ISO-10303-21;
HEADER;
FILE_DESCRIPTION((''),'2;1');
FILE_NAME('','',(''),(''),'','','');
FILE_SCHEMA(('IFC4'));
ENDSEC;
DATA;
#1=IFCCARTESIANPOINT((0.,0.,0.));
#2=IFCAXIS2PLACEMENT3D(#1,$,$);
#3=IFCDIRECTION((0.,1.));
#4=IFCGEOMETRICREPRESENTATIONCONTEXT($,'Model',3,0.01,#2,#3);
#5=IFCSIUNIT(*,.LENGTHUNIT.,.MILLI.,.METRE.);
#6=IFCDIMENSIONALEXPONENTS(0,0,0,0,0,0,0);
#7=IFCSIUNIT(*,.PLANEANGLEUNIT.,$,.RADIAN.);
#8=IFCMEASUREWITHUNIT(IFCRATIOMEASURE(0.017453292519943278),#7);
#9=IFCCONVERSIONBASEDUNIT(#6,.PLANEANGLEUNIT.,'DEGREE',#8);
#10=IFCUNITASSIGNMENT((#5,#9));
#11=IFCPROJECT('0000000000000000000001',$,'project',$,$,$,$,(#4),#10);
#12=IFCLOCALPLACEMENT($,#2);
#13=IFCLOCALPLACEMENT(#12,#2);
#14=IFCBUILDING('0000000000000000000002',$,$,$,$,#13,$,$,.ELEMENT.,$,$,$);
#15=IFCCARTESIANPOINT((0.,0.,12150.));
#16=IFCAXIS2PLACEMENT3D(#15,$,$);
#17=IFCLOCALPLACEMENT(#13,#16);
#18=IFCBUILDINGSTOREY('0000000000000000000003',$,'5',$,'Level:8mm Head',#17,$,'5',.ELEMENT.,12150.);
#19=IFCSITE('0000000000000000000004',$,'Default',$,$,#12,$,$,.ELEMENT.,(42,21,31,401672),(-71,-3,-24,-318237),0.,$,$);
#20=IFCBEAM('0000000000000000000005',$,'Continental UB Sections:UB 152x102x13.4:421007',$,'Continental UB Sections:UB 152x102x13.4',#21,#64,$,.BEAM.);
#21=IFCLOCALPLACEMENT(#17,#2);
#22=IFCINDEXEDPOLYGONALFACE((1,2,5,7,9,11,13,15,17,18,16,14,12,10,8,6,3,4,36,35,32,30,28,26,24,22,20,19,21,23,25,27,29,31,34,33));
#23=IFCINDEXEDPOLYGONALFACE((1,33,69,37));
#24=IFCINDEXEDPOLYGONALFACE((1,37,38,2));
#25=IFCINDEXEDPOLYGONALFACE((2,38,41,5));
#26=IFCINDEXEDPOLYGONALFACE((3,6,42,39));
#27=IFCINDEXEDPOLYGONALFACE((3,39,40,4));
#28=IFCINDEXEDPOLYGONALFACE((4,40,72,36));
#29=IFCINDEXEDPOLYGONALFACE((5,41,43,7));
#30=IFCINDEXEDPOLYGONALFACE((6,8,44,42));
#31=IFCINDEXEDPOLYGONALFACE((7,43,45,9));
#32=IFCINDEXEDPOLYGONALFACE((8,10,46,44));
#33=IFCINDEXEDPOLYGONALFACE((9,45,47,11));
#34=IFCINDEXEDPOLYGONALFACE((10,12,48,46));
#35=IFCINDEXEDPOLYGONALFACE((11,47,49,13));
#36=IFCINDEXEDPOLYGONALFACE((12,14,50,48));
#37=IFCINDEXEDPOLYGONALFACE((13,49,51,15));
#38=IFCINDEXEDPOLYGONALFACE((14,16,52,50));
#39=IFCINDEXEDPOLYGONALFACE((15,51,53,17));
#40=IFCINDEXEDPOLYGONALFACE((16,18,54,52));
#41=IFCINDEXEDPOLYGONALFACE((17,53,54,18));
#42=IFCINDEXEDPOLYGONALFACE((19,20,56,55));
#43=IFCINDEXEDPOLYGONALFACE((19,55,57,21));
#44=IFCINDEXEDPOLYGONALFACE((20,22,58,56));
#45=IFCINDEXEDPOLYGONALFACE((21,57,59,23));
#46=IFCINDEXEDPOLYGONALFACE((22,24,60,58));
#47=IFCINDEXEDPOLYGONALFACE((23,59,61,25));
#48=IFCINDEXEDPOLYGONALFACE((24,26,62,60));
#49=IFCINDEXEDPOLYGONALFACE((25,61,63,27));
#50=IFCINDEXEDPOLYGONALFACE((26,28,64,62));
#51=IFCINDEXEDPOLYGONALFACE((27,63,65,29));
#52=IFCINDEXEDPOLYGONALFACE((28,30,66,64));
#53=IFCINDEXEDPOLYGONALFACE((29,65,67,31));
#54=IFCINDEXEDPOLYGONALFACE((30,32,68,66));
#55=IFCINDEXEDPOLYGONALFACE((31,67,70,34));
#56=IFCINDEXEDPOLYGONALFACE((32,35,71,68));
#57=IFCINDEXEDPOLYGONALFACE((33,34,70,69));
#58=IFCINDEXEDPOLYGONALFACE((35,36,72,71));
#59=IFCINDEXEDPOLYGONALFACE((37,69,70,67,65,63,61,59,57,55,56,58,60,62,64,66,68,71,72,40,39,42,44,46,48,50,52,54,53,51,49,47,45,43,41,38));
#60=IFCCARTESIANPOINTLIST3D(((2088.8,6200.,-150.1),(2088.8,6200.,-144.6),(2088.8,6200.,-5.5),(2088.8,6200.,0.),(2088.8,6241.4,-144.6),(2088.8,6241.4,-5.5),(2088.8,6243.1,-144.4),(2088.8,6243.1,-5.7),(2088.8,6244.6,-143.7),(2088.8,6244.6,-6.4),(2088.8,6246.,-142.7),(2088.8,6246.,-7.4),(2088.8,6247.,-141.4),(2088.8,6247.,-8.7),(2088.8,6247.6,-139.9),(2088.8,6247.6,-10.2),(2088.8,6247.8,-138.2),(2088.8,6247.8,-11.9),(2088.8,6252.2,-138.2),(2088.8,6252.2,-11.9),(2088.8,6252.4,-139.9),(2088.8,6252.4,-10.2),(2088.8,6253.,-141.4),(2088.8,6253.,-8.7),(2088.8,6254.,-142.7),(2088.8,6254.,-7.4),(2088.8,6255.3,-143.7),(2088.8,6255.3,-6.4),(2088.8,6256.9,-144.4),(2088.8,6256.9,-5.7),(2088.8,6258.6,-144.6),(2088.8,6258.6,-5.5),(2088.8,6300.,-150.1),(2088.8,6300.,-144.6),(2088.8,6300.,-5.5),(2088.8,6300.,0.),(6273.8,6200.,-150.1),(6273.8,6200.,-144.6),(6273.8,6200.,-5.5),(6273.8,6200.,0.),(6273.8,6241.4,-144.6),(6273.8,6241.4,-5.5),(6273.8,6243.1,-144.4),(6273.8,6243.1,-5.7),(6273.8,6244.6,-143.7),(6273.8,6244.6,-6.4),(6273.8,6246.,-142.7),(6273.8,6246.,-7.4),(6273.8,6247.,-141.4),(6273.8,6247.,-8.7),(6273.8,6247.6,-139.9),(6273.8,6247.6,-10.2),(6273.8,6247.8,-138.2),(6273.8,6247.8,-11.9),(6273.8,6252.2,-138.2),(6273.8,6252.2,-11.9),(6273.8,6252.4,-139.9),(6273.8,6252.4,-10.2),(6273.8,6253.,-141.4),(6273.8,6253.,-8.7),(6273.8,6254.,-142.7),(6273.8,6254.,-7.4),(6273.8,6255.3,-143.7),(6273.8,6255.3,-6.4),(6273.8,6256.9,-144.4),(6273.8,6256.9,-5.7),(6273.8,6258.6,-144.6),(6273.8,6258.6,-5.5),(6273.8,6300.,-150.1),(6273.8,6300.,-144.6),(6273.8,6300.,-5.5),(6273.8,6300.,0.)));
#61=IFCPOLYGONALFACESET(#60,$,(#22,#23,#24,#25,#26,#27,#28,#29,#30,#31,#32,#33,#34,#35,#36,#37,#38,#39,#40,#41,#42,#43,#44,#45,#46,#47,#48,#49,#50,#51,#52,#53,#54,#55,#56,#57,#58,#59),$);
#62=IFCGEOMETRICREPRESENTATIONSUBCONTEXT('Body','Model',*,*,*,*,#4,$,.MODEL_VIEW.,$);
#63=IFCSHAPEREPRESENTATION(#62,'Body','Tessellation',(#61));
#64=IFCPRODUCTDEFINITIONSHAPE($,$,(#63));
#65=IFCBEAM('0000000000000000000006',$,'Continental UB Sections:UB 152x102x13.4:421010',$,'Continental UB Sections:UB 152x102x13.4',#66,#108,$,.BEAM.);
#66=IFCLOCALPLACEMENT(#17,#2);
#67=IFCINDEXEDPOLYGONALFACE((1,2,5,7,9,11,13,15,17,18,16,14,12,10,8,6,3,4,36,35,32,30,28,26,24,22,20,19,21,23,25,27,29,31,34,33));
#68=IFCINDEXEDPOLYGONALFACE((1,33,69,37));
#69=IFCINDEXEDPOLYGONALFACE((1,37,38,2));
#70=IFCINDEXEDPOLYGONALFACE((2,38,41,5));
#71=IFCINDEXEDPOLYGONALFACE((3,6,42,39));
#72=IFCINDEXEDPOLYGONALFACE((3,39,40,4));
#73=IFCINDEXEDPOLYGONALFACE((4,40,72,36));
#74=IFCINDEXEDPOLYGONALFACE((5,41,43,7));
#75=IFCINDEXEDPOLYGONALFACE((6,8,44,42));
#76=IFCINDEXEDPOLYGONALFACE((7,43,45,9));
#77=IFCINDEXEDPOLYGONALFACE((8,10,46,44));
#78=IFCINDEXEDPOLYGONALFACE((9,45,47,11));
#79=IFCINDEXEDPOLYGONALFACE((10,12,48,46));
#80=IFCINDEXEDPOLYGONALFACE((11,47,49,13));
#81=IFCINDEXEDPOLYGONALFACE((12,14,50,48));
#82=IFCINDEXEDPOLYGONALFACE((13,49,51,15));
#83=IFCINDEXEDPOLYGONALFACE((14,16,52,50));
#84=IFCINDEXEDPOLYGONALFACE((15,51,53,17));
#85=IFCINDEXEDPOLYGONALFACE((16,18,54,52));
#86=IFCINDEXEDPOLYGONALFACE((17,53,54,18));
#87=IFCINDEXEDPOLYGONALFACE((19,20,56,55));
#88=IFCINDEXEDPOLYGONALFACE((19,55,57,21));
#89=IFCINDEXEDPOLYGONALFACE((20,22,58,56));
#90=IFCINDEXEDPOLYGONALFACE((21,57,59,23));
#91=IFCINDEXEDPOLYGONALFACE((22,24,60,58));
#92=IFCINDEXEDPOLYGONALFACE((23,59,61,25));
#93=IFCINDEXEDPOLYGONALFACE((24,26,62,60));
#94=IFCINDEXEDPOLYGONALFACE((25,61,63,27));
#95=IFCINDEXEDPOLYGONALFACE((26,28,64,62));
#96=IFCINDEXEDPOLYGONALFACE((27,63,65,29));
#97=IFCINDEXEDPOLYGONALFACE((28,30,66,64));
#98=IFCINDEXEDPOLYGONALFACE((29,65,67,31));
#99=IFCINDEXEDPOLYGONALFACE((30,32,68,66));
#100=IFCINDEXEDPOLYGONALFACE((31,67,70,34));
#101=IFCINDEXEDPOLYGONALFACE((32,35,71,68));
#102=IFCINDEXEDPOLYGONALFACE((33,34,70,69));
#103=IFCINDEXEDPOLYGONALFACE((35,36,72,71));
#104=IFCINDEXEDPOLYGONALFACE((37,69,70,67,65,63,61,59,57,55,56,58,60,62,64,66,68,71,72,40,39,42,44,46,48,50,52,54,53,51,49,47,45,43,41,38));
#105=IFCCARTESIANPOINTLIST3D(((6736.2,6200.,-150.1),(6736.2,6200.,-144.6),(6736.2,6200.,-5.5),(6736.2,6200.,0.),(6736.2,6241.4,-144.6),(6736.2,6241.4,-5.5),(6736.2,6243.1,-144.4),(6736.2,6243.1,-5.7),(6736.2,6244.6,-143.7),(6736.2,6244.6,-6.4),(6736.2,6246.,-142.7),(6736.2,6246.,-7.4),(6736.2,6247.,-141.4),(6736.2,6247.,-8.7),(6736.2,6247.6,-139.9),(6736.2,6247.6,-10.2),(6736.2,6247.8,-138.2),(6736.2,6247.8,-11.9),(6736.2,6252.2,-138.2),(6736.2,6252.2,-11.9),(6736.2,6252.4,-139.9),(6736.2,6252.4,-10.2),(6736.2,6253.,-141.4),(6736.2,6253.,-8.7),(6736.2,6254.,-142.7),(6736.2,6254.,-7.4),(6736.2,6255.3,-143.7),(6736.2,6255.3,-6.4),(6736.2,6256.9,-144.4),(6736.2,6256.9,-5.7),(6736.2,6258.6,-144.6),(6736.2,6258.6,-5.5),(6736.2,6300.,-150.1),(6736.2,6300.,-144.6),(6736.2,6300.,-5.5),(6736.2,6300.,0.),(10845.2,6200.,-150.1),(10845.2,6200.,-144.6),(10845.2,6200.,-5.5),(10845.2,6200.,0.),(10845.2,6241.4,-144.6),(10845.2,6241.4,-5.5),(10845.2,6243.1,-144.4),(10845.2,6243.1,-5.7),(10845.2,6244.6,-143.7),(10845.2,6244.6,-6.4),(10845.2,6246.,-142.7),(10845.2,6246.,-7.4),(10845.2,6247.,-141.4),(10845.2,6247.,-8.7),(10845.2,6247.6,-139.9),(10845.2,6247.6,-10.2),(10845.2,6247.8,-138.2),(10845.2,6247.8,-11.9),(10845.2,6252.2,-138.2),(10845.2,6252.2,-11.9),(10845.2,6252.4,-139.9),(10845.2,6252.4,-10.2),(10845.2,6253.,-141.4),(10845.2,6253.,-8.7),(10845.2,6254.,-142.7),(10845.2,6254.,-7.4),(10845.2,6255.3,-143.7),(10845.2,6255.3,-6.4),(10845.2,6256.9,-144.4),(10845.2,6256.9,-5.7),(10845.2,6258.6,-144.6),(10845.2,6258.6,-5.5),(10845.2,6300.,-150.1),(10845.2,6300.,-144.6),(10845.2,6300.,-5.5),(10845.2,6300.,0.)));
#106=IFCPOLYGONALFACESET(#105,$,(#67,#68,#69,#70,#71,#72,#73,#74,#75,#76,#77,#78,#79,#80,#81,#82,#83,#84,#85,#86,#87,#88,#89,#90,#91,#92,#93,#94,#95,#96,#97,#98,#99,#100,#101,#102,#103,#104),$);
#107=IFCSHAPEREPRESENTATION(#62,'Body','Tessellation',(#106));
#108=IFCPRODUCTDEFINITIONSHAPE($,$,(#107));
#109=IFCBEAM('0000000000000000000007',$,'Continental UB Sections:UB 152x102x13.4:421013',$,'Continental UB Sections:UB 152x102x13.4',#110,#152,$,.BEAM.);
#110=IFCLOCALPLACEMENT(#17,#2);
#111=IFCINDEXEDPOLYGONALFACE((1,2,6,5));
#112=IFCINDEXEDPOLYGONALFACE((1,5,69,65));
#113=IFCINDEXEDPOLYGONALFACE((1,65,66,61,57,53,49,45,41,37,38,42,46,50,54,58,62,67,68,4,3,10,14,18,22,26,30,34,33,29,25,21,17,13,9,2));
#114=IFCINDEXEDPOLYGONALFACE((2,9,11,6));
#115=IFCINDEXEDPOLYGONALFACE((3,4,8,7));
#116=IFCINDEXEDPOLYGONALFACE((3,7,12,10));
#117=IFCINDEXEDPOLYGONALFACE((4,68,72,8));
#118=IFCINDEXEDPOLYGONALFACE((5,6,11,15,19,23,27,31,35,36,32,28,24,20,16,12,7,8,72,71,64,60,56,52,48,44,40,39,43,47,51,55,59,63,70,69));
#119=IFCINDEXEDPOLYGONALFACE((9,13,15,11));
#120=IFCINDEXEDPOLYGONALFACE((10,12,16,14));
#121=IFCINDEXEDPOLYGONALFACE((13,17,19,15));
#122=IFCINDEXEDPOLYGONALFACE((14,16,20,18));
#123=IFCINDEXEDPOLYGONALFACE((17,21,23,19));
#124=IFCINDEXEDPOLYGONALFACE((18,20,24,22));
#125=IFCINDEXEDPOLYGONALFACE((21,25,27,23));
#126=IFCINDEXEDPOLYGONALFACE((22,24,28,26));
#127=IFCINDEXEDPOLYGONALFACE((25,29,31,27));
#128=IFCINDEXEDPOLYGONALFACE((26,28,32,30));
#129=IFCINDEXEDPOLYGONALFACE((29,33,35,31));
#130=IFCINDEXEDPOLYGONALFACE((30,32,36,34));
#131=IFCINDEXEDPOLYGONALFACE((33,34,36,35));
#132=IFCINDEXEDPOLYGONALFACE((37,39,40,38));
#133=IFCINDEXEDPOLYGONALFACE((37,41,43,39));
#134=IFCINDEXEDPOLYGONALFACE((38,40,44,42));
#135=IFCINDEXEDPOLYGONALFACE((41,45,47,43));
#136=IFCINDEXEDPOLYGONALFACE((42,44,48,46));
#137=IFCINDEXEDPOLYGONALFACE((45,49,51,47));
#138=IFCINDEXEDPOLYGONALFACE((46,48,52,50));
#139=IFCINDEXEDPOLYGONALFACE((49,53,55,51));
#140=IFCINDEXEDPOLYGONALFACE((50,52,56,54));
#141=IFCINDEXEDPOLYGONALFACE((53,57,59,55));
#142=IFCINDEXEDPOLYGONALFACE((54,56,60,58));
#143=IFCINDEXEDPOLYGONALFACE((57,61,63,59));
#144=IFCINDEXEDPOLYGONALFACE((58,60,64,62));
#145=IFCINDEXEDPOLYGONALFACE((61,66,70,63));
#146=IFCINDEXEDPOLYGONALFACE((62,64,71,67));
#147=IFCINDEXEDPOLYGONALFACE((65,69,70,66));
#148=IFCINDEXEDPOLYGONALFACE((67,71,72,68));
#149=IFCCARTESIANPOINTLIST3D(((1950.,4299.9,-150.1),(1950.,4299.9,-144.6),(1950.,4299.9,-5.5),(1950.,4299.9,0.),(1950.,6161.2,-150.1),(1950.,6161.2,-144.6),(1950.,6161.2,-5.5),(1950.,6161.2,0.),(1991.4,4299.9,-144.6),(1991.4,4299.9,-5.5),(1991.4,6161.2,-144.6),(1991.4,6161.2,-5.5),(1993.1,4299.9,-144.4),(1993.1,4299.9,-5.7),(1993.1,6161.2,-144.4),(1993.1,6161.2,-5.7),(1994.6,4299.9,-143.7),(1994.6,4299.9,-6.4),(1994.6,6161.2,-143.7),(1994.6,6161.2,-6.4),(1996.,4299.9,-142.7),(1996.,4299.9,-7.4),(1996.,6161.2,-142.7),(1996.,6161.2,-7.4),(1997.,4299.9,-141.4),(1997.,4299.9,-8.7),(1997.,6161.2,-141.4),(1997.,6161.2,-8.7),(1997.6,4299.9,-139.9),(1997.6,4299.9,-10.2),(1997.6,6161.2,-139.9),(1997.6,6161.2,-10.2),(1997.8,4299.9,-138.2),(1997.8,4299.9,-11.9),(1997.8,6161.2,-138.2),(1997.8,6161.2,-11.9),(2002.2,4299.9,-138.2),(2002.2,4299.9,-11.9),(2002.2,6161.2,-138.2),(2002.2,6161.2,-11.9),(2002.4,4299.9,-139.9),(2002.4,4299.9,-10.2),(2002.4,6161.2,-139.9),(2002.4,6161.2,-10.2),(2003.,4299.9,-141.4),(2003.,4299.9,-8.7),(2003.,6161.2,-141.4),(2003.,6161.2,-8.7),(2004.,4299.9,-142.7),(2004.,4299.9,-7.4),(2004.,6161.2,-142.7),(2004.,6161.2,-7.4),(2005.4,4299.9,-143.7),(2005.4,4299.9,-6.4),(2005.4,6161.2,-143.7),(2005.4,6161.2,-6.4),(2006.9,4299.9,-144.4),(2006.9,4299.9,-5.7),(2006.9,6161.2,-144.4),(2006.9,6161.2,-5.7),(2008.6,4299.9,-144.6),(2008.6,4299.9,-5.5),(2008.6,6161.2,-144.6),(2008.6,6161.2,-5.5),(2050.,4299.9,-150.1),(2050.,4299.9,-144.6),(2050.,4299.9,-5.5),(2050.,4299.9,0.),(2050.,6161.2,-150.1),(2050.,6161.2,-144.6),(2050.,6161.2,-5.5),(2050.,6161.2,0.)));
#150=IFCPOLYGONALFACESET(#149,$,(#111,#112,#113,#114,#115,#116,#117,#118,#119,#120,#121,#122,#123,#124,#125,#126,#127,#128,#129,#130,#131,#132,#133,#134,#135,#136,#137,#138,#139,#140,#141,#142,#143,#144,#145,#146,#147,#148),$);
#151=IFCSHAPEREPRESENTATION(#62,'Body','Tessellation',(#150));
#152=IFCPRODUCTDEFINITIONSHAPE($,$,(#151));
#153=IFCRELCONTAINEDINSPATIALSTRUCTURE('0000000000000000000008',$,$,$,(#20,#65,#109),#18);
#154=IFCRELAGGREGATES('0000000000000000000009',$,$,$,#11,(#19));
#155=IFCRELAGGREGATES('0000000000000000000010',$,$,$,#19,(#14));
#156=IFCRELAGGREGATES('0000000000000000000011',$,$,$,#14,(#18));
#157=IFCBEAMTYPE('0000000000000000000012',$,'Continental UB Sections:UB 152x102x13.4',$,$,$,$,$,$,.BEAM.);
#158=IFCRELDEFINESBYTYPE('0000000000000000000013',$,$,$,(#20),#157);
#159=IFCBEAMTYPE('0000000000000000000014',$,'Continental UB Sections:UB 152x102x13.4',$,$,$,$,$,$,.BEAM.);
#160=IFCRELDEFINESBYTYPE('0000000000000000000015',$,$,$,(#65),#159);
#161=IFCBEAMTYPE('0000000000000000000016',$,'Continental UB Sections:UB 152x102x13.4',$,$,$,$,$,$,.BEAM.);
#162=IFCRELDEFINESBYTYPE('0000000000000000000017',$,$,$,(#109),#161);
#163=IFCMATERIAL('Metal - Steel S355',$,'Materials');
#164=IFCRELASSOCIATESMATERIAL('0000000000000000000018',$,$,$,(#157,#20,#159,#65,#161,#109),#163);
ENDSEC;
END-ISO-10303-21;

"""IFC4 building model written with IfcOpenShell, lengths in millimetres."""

from ifc_helpers import new_model, entity, si_unit, converted_unit, direction, frame, origin, place, context, subcontext, project, spatial, line, arc, indexed_curve, outline, extrude, source, transform, mapped, material, type_object, type_shapes, element, save


model = new_model("IFC4")

# Units and contexts
model_context = context("Model", 3, precision=0.01, world=origin(), true_north=direction((0.0, 1.0)))
body_context = subcontext(model_context, "Body", "Model", "MODEL_VIEW")
ifc_project = project(units=[si_unit("LENGTHUNIT", "METRE", prefix="MILLI"), converted_unit("PLANEANGLEUNIT", "DEGREE", entity("IfcRatioMeasure", 0.017453292519943278), si_unit("PLANEANGLEUNIT", "RADIAN"), dimensions=[0, 0, 0, 0, 0, 0, 0])], contexts=[model_context])

# Site, building, storey
site_placement = place(None, origin())
site = spatial("IfcSite", under=ifc_project, at=site_placement, Name="Default", CompositionType="ELEMENT", RefLatitude=(42, 21, 31, 401672), RefLongitude=(-71, -3, -24, -318237), RefElevation=0.0)
building_placement = place(site_placement, origin())
building = spatial("IfcBuilding", under=site, at=building_placement, CompositionType="ELEMENT")
storey_placement = place(building_placement, frame((0.0, 0.0, 12150.0)))
storey = spatial("IfcBuildingStorey", under=building, at=storey_placement, Name="5", ObjectType="Level:8mm Head", LongName="5", CompositionType="ELEMENT", Elevation=12150.0)

# Beams
ifc_material = material(Name="Metal - Steel S355", Category="Materials")
beam_type_1 = type_object("IfcBeamType", Name="Continental UB Sections:UB 152x102x13.4", PredefinedType="BEAM", material=ifc_material)
shared_shape_1 = source(origin(), body_context, "Body", "SweptSolid", [
    extrude(outline(indexed_curve([(-75.0, -50.1), (-69.6, -50.1), (-69.6, -8.5), (-67.7, -4.0), (-63.2, -2.1), (63.1, -2.1), (67.7, -4.0), (69.5, -8.5), (69.5, -50.1), (75.1, -50.1), (75.1, 50.1), (69.5, 50.1), (69.5, 8.6), (67.7, 4.0), (63.1, 2.2), (-63.2, 2.2), (-67.7, 4.0), (-69.6, 8.6), (-69.6, 50.0), (-75.0, 50.0)], segments=[line(1, 2, 3), arc(3, 4, 5), line(5, 6), arc(6, 7, 8), line(8, 9, 10, 11, 12, 13), arc(13, 14, 15), line(15, 16), arc(16, 17, 18), line(18, 19, 20, 1)], self_intersect=False)), frame((-2163.7, 0.0, 0.0), z_axis=(1.0, 0.0, 0.0), x_axis=(0.0, 0.0, -1.0)), (0.0, 0.0, 1.0), 4185.0),
])
type_shapes(beam_type_1, [shared_shape_1])
beam_1_placement = place(storey_placement, frame((4252.5, 6250.0, -75.1)))
element("IfcBeam", 1, at=beam_1_placement, inside=storey, type_object=beam_type_1, material=ifc_material, Name="Continental UB Sections:UB 152x102x13.4:421007", ObjectType="Continental UB Sections:UB 152x102x13.4", PredefinedType="BEAM", context=body_context, shape_type="MappedRepresentation", body=[
    mapped(shared_shape_1, transform((0.0, 0.0, 0.0), scale=1.0)),
])
beam_type_2 = type_object("IfcBeamType", Name="Continental UB Sections:UB 152x102x13.4", PredefinedType="BEAM", material=ifc_material)
shared_shape_2 = source(origin(), body_context, "Body", "SweptSolid", [
    extrude(outline(indexed_curve([(-75.0, -50.1), (-69.6, -50.1), (-69.6, -8.5), (-67.7, -4.0), (-63.2, -2.1), (63.1, -2.1), (67.7, -4.0), (69.5, -8.5), (69.5, -50.1), (75.1, -50.1), (75.1, 50.1), (69.5, 50.1), (69.5, 8.6), (67.7, 4.0), (63.1, 2.2), (-63.2, 2.2), (-67.7, 4.0), (-69.6, 8.6), (-69.6, 50.0), (-75.0, 50.0)], segments=[line(1, 2, 3), arc(3, 4, 5), line(5, 6), arc(6, 7, 8), line(8, 9, 10, 11, 12, 13), arc(13, 14, 15), line(15, 16), arc(16, 17, 18), line(18, 19, 20, 1)], self_intersect=False)), frame((-2021.3, 0.0, 0.0), z_axis=(1.0, 0.0, 0.0), x_axis=(0.0, 0.0, -1.0)), (0.0, 0.0, 1.0), 4109.0),
])
type_shapes(beam_type_2, [shared_shape_2])
beam_2_placement = place(storey_placement, frame((8757.5, 6250.0, -75.1)))
element("IfcBeam", 2, at=beam_2_placement, inside=storey, type_object=beam_type_2, material=ifc_material, Name="Continental UB Sections:UB 152x102x13.4:421010", ObjectType="Continental UB Sections:UB 152x102x13.4", PredefinedType="BEAM", context=body_context, shape_type="MappedRepresentation", body=[
    mapped(shared_shape_2, transform((0.0, 0.0, 0.0), scale=1.0)),
])
beam_type_3 = type_object("IfcBeamType", Name="Continental UB Sections:UB 152x102x13.4", PredefinedType="BEAM", material=ifc_material)
shared_shape_3 = source(origin(), body_context, "Body", "SweptSolid", [
    extrude(outline(indexed_curve([(-75.0, -50.1), (-69.6, -50.1), (-69.6, -8.5), (-67.7, -4.0), (-63.2, -2.1), (63.1, -2.1), (67.7, -4.0), (69.5, -8.5), (69.5, -50.1), (75.1, -50.1), (75.1, 50.1), (69.5, 50.1), (69.5, 8.6), (67.7, 4.0), (63.1, 2.2), (-63.2, 2.2), (-67.7, 4.0), (-69.6, 8.6), (-69.6, 50.0), (-75.0, 50.0)], segments=[line(1, 2, 3), arc(3, 4, 5), line(5, 6), arc(6, 7, 8), line(8, 9, 10, 11, 12, 13), arc(13, 14, 15), line(15, 16), arc(16, 17, 18), line(18, 19, 20, 1)], self_intersect=False)), frame((-1000.1, 0.0, 0.0), z_axis=(1.0, 0.0, 0.0), x_axis=(0.0, 0.0, -1.0)), (0.0, 0.0, 1.0), 1861.3),
])
type_shapes(beam_type_3, [shared_shape_3])
beam_3_placement = place(storey_placement, frame((2000.0, 5300.0, -75.1), z_axis=(0.0, 0.0, 1.0), x_axis=(0.0, 1.0, 0.0)))
element("IfcBeam", 3, at=beam_3_placement, inside=storey, type_object=beam_type_3, material=ifc_material, Name="Continental UB Sections:UB 152x102x13.4:421013", ObjectType="Continental UB Sections:UB 152x102x13.4", PredefinedType="BEAM", context=body_context, shape_type="MappedRepresentation", body=[
    mapped(shared_shape_3, transform((0.0, 0.0, 0.0), scale=1.0)),
])

save(model, "model.ifc")
